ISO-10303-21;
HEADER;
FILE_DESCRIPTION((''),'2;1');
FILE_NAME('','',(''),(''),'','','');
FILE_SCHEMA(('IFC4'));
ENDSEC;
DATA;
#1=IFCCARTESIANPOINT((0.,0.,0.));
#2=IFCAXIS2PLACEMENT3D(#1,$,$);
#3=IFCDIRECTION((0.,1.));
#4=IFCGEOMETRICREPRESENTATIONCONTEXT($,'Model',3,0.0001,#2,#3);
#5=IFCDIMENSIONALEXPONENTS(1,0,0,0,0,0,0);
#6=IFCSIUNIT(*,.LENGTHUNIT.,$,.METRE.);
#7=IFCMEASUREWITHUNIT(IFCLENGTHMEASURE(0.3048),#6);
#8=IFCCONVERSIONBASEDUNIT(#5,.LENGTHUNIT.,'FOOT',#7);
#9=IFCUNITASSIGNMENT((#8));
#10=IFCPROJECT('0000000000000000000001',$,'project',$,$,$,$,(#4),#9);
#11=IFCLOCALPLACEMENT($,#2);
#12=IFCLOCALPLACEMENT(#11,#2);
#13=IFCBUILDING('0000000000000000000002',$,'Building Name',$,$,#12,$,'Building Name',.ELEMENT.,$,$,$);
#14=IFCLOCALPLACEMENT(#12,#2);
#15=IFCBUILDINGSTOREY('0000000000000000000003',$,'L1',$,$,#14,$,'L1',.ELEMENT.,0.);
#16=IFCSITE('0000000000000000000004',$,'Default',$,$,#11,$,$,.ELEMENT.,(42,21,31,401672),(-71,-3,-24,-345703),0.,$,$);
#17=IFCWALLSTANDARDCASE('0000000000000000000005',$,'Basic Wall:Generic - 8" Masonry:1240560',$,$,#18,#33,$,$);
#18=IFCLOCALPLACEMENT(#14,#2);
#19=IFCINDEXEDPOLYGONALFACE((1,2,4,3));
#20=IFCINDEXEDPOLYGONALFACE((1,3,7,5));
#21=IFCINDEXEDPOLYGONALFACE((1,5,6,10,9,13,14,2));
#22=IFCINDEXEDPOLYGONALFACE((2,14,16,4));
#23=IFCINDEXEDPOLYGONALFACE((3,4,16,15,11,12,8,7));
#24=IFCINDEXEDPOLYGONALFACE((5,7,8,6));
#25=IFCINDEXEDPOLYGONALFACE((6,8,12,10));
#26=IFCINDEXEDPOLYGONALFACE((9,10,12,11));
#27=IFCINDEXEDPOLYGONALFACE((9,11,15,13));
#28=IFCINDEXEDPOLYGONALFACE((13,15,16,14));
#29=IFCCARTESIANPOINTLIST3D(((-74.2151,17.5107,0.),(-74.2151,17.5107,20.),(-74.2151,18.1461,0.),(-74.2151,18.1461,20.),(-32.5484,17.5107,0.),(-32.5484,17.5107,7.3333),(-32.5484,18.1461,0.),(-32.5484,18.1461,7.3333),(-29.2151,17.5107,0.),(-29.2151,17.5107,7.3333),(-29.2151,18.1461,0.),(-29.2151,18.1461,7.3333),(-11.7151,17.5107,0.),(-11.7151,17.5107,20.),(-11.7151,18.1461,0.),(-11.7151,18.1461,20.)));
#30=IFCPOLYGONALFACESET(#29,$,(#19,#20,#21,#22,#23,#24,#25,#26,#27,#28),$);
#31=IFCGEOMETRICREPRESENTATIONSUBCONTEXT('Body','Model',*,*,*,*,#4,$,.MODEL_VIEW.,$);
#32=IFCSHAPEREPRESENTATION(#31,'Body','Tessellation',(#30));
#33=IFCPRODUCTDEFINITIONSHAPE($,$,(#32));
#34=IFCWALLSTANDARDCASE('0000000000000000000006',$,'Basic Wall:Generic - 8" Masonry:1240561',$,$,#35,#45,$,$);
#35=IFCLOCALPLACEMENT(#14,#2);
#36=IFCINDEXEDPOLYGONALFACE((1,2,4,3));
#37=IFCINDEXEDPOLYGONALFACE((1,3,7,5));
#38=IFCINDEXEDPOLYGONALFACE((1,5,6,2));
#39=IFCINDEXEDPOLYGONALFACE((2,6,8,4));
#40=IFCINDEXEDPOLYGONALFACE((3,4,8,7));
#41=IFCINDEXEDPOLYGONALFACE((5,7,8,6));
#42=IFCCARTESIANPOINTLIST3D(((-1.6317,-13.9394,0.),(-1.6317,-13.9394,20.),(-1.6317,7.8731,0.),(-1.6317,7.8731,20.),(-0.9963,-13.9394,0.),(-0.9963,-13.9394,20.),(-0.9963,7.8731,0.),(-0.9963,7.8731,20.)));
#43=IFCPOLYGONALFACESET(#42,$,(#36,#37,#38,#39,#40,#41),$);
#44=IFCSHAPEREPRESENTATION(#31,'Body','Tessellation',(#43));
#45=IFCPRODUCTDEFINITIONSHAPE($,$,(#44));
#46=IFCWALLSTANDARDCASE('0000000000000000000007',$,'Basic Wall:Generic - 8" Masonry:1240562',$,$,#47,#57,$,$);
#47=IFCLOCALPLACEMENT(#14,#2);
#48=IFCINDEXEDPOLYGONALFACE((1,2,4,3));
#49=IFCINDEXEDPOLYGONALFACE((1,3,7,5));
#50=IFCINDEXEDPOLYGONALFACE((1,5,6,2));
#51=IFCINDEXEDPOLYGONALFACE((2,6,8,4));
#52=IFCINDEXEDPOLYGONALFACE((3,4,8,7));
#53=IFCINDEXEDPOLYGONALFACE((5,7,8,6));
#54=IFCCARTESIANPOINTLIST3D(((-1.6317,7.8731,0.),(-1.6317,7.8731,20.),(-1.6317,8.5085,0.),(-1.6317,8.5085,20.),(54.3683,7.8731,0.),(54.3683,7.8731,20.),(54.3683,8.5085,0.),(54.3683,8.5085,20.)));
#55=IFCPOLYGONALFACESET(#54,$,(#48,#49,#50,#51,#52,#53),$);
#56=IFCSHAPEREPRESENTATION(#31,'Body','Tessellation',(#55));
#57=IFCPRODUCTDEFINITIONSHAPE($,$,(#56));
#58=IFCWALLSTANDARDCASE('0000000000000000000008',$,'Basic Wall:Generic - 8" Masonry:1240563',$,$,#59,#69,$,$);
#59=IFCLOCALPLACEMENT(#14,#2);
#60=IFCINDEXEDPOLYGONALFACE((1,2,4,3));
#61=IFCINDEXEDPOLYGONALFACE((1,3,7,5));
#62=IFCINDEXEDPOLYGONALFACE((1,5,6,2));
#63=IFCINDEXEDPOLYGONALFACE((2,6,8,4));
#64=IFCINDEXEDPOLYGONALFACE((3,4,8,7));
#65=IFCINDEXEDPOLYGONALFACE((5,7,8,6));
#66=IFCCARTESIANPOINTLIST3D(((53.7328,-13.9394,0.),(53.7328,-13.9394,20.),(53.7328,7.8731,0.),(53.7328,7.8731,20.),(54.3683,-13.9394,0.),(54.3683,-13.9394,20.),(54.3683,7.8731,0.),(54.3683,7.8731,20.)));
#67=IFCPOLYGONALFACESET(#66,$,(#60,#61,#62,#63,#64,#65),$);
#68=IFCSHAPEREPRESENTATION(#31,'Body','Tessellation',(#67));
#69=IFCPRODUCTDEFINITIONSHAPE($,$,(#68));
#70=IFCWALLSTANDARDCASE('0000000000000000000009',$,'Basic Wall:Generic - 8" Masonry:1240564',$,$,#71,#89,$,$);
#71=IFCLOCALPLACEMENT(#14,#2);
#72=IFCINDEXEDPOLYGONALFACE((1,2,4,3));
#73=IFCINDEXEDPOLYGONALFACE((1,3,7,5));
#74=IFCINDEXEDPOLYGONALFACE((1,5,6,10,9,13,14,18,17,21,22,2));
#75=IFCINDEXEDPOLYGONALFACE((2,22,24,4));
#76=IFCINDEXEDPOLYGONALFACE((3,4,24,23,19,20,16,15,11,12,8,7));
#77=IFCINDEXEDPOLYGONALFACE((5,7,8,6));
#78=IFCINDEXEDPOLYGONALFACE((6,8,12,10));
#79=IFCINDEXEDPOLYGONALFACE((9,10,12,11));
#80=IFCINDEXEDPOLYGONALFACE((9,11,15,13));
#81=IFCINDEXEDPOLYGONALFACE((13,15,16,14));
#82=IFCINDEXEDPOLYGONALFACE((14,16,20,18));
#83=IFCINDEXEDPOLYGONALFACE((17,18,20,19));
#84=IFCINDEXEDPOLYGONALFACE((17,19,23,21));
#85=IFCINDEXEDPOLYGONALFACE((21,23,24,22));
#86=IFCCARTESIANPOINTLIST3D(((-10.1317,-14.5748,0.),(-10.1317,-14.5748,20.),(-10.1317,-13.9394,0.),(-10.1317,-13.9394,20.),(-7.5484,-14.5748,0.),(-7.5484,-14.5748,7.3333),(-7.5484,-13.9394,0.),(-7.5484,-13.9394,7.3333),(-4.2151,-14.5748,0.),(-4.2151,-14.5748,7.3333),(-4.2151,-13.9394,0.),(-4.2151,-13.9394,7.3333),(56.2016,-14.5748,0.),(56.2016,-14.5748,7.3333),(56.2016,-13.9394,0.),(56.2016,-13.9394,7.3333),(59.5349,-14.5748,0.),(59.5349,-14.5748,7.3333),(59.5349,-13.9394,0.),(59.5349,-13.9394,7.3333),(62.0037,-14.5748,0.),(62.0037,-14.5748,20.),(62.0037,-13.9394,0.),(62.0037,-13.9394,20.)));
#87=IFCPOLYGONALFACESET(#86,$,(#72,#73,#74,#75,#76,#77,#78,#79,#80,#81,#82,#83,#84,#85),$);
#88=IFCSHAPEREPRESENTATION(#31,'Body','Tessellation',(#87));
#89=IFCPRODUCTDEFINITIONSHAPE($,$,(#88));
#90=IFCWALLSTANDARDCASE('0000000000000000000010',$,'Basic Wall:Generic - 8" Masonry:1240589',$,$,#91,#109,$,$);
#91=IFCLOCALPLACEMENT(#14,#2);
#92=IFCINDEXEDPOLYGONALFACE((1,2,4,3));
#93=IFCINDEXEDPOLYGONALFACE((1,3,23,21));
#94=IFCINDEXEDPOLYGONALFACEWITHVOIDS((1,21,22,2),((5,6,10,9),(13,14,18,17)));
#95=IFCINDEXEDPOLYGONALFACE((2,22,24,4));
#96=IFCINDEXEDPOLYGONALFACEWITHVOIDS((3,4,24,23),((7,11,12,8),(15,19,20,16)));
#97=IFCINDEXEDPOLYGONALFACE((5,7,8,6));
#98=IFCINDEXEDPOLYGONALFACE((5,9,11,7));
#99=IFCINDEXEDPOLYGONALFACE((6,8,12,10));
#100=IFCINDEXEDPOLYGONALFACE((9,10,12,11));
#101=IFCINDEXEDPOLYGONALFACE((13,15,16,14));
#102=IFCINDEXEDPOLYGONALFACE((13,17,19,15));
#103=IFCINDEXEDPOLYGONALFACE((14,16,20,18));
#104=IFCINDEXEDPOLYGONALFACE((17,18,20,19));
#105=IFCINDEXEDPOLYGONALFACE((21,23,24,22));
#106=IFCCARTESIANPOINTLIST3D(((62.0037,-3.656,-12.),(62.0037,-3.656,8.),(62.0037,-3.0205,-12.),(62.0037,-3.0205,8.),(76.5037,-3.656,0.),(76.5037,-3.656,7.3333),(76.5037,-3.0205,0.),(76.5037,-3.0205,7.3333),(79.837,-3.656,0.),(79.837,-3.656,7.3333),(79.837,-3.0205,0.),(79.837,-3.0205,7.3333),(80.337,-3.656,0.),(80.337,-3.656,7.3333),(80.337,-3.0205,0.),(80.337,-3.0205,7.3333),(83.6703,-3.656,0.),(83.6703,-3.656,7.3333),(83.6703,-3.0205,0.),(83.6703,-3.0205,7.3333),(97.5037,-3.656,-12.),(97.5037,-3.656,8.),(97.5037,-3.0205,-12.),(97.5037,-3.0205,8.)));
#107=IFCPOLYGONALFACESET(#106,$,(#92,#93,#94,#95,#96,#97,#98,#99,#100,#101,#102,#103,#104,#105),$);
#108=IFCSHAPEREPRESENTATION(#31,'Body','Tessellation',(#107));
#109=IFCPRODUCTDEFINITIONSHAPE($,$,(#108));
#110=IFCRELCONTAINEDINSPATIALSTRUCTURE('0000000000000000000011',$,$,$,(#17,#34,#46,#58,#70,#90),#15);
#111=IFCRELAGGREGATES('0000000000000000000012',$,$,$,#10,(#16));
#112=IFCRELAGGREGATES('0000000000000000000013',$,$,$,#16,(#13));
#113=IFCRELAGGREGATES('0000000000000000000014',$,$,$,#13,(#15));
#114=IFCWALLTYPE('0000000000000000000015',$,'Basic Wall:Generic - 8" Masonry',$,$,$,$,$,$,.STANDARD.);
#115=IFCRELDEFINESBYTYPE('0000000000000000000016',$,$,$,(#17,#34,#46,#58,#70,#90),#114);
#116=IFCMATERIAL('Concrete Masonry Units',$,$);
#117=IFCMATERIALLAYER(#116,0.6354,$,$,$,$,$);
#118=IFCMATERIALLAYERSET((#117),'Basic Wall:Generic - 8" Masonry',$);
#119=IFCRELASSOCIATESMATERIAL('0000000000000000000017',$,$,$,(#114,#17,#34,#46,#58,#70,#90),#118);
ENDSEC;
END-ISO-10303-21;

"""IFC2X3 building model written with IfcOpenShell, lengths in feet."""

from ifc_helpers import new_model, entity, si_unit, converted_unit, direction, frame, frame_2d, origin, place, context, subcontext, project, spatial, rectangle, extrude, material, layer, layer_set, layer_usage, type_object, element, save


model = new_model("IFC2X3")

# Units and contexts
model_context = context("Model", 3, precision=0.0001, world=origin(), true_north=direction((0.0, 1.0)))
body_context = subcontext(model_context, "Body", "Model", "MODEL_VIEW")
ifc_project = project(units=[converted_unit("LENGTHUNIT", "FOOT", entity("IfcLengthMeasure", 0.3048), si_unit("LENGTHUNIT", "METRE"), dimensions=[1, 0, 0, 0, 0, 0, 0])], contexts=[model_context])

# Site, building, storey
site_placement = place(None, origin())
site = spatial("IfcSite", under=ifc_project, at=site_placement, Name="Default", CompositionType="ELEMENT", RefLatitude=(42, 21, 31, 401672), RefLongitude=(-71, -3, -24, -345703), RefElevation=0.0)
building_placement = place(site_placement, origin())
building = spatial("IfcBuilding", under=site, at=building_placement, Name="Building Name", LongName="Building Name", CompositionType="ELEMENT")
storey_placement = place(building_placement, origin())
storey = spatial("IfcBuildingStorey", under=building, at=storey_placement, Name="L1", LongName="L1", CompositionType="ELEMENT", Elevation=0.0)

# Shared definitions
ifc_material = material(Name="Concrete Masonry Units")
ifc_layer = layer(ifc_material, 0.6354)
ifc_layer_set = layer_set([ifc_layer], Name="Basic Wall:Generic - 8\" Masonry")
wall_type = type_object("IfcWallType", Name="Basic Wall:Generic - 8\" Masonry", PredefinedType="STANDARD", material=ifc_layer_set)

# Wall, opening
ifc_layer_usage_1 = layer_usage(ifc_layer_set, "AXIS2", "NEGATIVE", 0.3177)
wall_1_placement = place(storey_placement, frame((-11.7151, 17.8284, 0.0), z_axis=(0.0, 0.0, 1.0), x_axis=(-1.0, 0.0, 0.0)))
wall_1 = element("IfcWallStandardCase", 1, at=wall_1_placement, inside=storey, type_object=wall_type, material=ifc_layer_usage_1, Name="Basic Wall:Generic - 8\" Masonry:1240560", context=body_context, shape_type="SweptSolid", body=[
    extrude(rectangle(XDim=62.5, YDim=0.6354, at=frame_2d((31.25, 0.0), x_axis=(1.0, 0.0))), origin(), (0.0, 0.0, 1.0), 20.0),
])
opening_1_placement = place(wall_1_placement, frame((20.8333, 0.3177, 0.0)))
element("IfcOpeningElement", 2, at=opening_1_placement, cuts=wall_1, ObjectType="Opening", context=body_context, shape_type="SweptSolid", body=[
    extrude(rectangle(XDim=7.3333, YDim=3.3333, at=frame_2d((3.6667, 1.6667), x_axis=(1.0, 0.0))), frame((0.0, 0.0, 0.0), z_axis=(0.0, -1.0, 0.0), x_axis=(0.0, 0.0, 1.0)), (0.0, 0.0, 1.0), 0.6354),
])

# Walls
ifc_layer_usage_2 = layer_usage(ifc_layer_set, "AXIS2", "NEGATIVE", 0.3177)
wall_2_placement = place(storey_placement, frame((-1.314, -13.9394, 0.0), z_axis=(0.0, 0.0, 1.0), x_axis=(0.0, 1.0, 0.0)))
element("IfcWallStandardCase", 3, at=wall_2_placement, inside=storey, type_object=wall_type, material=ifc_layer_usage_2, Name="Basic Wall:Generic - 8\" Masonry:1240561", context=body_context, shape_type="SweptSolid", body=[
    extrude(rectangle(XDim=21.8125, YDim=0.6354, at=frame_2d((10.9063, 0.0), x_axis=(-1.0, 0.0))), origin(), (0.0, 0.0, 1.0), 20.0),
])
ifc_layer_usage_3 = layer_usage(ifc_layer_set, "AXIS2", "NEGATIVE", 0.3177)
wall_3_placement = place(storey_placement, frame((-1.6317, 8.1908, 0.0)))
element("IfcWallStandardCase", 4, at=wall_3_placement, inside=storey, type_object=wall_type, material=ifc_layer_usage_3, Name="Basic Wall:Generic - 8\" Masonry:1240562", context=body_context, shape_type="SweptSolid", body=[
    extrude(rectangle(XDim=56.0, YDim=0.6354, at=frame_2d((28.0, 0.0), x_axis=(-1.0, 0.0))), origin(), (0.0, 0.0, 1.0), 20.0),
])
ifc_layer_usage_4 = layer_usage(ifc_layer_set, "AXIS2", "NEGATIVE", 0.3177)
wall_4_placement = place(storey_placement, frame((54.0505, 7.8731, 0.0), z_axis=(0.0, 0.0, 1.0), x_axis=(0.0, -1.0, 0.0)))
element("IfcWallStandardCase", 5, at=wall_4_placement, inside=storey, type_object=wall_type, material=ifc_layer_usage_4, Name="Basic Wall:Generic - 8\" Masonry:1240563", context=body_context, shape_type="SweptSolid", body=[
    extrude(rectangle(XDim=21.8125, YDim=0.6354, at=frame_2d((10.9063, 0.0), x_axis=(-1.0, 0.0))), origin(), (0.0, 0.0, 1.0), 20.0),
])

# Walls, openings
ifc_layer_usage_5 = layer_usage(ifc_layer_set, "AXIS2", "NEGATIVE", 0.3177)
wall_5_placement = place(storey_placement, frame((62.0037, -14.2571, 0.0), z_axis=(0.0, 0.0, 1.0), x_axis=(-1.0, 0.0, 0.0)))
wall_5 = element("IfcWallStandardCase", 6, at=wall_5_placement, inside=storey, type_object=wall_type, material=ifc_layer_usage_5, Name="Basic Wall:Generic - 8\" Masonry:1240564", context=body_context, shape_type="SweptSolid", body=[
    extrude(rectangle(XDim=72.1354, YDim=0.6354, at=frame_2d((36.0677, 0.0), x_axis=(-1.0, 0.0))), origin(), (0.0, 0.0, 1.0), 20.0),
])
opening_2_placement = place(wall_5_placement, frame((66.2188, -0.3177, 0.0)))
element("IfcOpeningElement", 7, at=opening_2_placement, cuts=wall_5, ObjectType="Opening", context=body_context, shape_type="SweptSolid", body=[
    extrude(rectangle(XDim=7.3333, YDim=3.3333, at=frame_2d((3.6667, 1.6667), x_axis=(1.0, 0.0))), frame((0.0, 0.0, 0.0), z_axis=(0.0, 1.0, 0.0), x_axis=(0.0, 0.0, 1.0)), (0.0, 0.0, 1.0), 0.6354),
])
opening_3_placement = place(wall_5_placement, frame((2.4688, -0.3177, 0.0)))
element("IfcOpeningElement", 8, at=opening_3_placement, cuts=wall_5, ObjectType="Opening", context=body_context, shape_type="SweptSolid", body=[
    extrude(rectangle(XDim=7.3333, YDim=3.3333, at=frame_2d((3.6667, 1.6667), x_axis=(1.0, 0.0))), frame((0.0, 0.0, 0.0), z_axis=(0.0, 1.0, 0.0), x_axis=(0.0, 0.0, 1.0)), (0.0, 0.0, 1.0), 0.6354),
])
ifc_layer_usage_6 = layer_usage(ifc_layer_set, "AXIS2", "NEGATIVE", 0.3177)
wall_6_placement = place(storey_placement, frame((62.0037, -3.3382, -12.0)))
wall_6 = element("IfcWallStandardCase", 9, at=wall_6_placement, inside=storey, type_object=wall_type, material=ifc_layer_usage_6, Name="Basic Wall:Generic - 8\" Masonry:1240589", context=body_context, shape_type="SweptSolid", body=[
    extrude(rectangle(XDim=35.5, YDim=0.6354, at=frame_2d((17.75, 0.0), x_axis=(-1.0, 0.0))), origin(), (0.0, 0.0, 1.0), 20.0),
])
opening_4_placement = place(wall_6_placement, frame((14.5, -0.3177, 12.0)))
element("IfcOpeningElement", 10, at=opening_4_placement, cuts=wall_6, ObjectType="Opening", context=body_context, shape_type="SweptSolid", body=[
    extrude(rectangle(XDim=7.3333, YDim=3.3333, at=frame_2d((3.6667, 1.6667), x_axis=(1.0, 0.0))), frame((0.0, 0.0, 0.0), z_axis=(0.0, 1.0, 0.0), x_axis=(0.0, 0.0, 1.0)), (0.0, 0.0, 1.0), 0.6354),
])
opening_5_placement = place(wall_6_placement, frame((18.3333, -0.3177, 12.0)))
element("IfcOpeningElement", 11, at=opening_5_placement, cuts=wall_6, ObjectType="Opening", context=body_context, shape_type="SweptSolid", body=[
    extrude(rectangle(XDim=7.3333, YDim=3.3333, at=frame_2d((3.6667, 1.6667), x_axis=(1.0, 0.0))), frame((0.0, 0.0, 0.0), z_axis=(0.0, 1.0, 0.0), x_axis=(0.0, 0.0, 1.0)), (0.0, 0.0, 1.0), 0.6354),
])

save(model, "model.ifc")
